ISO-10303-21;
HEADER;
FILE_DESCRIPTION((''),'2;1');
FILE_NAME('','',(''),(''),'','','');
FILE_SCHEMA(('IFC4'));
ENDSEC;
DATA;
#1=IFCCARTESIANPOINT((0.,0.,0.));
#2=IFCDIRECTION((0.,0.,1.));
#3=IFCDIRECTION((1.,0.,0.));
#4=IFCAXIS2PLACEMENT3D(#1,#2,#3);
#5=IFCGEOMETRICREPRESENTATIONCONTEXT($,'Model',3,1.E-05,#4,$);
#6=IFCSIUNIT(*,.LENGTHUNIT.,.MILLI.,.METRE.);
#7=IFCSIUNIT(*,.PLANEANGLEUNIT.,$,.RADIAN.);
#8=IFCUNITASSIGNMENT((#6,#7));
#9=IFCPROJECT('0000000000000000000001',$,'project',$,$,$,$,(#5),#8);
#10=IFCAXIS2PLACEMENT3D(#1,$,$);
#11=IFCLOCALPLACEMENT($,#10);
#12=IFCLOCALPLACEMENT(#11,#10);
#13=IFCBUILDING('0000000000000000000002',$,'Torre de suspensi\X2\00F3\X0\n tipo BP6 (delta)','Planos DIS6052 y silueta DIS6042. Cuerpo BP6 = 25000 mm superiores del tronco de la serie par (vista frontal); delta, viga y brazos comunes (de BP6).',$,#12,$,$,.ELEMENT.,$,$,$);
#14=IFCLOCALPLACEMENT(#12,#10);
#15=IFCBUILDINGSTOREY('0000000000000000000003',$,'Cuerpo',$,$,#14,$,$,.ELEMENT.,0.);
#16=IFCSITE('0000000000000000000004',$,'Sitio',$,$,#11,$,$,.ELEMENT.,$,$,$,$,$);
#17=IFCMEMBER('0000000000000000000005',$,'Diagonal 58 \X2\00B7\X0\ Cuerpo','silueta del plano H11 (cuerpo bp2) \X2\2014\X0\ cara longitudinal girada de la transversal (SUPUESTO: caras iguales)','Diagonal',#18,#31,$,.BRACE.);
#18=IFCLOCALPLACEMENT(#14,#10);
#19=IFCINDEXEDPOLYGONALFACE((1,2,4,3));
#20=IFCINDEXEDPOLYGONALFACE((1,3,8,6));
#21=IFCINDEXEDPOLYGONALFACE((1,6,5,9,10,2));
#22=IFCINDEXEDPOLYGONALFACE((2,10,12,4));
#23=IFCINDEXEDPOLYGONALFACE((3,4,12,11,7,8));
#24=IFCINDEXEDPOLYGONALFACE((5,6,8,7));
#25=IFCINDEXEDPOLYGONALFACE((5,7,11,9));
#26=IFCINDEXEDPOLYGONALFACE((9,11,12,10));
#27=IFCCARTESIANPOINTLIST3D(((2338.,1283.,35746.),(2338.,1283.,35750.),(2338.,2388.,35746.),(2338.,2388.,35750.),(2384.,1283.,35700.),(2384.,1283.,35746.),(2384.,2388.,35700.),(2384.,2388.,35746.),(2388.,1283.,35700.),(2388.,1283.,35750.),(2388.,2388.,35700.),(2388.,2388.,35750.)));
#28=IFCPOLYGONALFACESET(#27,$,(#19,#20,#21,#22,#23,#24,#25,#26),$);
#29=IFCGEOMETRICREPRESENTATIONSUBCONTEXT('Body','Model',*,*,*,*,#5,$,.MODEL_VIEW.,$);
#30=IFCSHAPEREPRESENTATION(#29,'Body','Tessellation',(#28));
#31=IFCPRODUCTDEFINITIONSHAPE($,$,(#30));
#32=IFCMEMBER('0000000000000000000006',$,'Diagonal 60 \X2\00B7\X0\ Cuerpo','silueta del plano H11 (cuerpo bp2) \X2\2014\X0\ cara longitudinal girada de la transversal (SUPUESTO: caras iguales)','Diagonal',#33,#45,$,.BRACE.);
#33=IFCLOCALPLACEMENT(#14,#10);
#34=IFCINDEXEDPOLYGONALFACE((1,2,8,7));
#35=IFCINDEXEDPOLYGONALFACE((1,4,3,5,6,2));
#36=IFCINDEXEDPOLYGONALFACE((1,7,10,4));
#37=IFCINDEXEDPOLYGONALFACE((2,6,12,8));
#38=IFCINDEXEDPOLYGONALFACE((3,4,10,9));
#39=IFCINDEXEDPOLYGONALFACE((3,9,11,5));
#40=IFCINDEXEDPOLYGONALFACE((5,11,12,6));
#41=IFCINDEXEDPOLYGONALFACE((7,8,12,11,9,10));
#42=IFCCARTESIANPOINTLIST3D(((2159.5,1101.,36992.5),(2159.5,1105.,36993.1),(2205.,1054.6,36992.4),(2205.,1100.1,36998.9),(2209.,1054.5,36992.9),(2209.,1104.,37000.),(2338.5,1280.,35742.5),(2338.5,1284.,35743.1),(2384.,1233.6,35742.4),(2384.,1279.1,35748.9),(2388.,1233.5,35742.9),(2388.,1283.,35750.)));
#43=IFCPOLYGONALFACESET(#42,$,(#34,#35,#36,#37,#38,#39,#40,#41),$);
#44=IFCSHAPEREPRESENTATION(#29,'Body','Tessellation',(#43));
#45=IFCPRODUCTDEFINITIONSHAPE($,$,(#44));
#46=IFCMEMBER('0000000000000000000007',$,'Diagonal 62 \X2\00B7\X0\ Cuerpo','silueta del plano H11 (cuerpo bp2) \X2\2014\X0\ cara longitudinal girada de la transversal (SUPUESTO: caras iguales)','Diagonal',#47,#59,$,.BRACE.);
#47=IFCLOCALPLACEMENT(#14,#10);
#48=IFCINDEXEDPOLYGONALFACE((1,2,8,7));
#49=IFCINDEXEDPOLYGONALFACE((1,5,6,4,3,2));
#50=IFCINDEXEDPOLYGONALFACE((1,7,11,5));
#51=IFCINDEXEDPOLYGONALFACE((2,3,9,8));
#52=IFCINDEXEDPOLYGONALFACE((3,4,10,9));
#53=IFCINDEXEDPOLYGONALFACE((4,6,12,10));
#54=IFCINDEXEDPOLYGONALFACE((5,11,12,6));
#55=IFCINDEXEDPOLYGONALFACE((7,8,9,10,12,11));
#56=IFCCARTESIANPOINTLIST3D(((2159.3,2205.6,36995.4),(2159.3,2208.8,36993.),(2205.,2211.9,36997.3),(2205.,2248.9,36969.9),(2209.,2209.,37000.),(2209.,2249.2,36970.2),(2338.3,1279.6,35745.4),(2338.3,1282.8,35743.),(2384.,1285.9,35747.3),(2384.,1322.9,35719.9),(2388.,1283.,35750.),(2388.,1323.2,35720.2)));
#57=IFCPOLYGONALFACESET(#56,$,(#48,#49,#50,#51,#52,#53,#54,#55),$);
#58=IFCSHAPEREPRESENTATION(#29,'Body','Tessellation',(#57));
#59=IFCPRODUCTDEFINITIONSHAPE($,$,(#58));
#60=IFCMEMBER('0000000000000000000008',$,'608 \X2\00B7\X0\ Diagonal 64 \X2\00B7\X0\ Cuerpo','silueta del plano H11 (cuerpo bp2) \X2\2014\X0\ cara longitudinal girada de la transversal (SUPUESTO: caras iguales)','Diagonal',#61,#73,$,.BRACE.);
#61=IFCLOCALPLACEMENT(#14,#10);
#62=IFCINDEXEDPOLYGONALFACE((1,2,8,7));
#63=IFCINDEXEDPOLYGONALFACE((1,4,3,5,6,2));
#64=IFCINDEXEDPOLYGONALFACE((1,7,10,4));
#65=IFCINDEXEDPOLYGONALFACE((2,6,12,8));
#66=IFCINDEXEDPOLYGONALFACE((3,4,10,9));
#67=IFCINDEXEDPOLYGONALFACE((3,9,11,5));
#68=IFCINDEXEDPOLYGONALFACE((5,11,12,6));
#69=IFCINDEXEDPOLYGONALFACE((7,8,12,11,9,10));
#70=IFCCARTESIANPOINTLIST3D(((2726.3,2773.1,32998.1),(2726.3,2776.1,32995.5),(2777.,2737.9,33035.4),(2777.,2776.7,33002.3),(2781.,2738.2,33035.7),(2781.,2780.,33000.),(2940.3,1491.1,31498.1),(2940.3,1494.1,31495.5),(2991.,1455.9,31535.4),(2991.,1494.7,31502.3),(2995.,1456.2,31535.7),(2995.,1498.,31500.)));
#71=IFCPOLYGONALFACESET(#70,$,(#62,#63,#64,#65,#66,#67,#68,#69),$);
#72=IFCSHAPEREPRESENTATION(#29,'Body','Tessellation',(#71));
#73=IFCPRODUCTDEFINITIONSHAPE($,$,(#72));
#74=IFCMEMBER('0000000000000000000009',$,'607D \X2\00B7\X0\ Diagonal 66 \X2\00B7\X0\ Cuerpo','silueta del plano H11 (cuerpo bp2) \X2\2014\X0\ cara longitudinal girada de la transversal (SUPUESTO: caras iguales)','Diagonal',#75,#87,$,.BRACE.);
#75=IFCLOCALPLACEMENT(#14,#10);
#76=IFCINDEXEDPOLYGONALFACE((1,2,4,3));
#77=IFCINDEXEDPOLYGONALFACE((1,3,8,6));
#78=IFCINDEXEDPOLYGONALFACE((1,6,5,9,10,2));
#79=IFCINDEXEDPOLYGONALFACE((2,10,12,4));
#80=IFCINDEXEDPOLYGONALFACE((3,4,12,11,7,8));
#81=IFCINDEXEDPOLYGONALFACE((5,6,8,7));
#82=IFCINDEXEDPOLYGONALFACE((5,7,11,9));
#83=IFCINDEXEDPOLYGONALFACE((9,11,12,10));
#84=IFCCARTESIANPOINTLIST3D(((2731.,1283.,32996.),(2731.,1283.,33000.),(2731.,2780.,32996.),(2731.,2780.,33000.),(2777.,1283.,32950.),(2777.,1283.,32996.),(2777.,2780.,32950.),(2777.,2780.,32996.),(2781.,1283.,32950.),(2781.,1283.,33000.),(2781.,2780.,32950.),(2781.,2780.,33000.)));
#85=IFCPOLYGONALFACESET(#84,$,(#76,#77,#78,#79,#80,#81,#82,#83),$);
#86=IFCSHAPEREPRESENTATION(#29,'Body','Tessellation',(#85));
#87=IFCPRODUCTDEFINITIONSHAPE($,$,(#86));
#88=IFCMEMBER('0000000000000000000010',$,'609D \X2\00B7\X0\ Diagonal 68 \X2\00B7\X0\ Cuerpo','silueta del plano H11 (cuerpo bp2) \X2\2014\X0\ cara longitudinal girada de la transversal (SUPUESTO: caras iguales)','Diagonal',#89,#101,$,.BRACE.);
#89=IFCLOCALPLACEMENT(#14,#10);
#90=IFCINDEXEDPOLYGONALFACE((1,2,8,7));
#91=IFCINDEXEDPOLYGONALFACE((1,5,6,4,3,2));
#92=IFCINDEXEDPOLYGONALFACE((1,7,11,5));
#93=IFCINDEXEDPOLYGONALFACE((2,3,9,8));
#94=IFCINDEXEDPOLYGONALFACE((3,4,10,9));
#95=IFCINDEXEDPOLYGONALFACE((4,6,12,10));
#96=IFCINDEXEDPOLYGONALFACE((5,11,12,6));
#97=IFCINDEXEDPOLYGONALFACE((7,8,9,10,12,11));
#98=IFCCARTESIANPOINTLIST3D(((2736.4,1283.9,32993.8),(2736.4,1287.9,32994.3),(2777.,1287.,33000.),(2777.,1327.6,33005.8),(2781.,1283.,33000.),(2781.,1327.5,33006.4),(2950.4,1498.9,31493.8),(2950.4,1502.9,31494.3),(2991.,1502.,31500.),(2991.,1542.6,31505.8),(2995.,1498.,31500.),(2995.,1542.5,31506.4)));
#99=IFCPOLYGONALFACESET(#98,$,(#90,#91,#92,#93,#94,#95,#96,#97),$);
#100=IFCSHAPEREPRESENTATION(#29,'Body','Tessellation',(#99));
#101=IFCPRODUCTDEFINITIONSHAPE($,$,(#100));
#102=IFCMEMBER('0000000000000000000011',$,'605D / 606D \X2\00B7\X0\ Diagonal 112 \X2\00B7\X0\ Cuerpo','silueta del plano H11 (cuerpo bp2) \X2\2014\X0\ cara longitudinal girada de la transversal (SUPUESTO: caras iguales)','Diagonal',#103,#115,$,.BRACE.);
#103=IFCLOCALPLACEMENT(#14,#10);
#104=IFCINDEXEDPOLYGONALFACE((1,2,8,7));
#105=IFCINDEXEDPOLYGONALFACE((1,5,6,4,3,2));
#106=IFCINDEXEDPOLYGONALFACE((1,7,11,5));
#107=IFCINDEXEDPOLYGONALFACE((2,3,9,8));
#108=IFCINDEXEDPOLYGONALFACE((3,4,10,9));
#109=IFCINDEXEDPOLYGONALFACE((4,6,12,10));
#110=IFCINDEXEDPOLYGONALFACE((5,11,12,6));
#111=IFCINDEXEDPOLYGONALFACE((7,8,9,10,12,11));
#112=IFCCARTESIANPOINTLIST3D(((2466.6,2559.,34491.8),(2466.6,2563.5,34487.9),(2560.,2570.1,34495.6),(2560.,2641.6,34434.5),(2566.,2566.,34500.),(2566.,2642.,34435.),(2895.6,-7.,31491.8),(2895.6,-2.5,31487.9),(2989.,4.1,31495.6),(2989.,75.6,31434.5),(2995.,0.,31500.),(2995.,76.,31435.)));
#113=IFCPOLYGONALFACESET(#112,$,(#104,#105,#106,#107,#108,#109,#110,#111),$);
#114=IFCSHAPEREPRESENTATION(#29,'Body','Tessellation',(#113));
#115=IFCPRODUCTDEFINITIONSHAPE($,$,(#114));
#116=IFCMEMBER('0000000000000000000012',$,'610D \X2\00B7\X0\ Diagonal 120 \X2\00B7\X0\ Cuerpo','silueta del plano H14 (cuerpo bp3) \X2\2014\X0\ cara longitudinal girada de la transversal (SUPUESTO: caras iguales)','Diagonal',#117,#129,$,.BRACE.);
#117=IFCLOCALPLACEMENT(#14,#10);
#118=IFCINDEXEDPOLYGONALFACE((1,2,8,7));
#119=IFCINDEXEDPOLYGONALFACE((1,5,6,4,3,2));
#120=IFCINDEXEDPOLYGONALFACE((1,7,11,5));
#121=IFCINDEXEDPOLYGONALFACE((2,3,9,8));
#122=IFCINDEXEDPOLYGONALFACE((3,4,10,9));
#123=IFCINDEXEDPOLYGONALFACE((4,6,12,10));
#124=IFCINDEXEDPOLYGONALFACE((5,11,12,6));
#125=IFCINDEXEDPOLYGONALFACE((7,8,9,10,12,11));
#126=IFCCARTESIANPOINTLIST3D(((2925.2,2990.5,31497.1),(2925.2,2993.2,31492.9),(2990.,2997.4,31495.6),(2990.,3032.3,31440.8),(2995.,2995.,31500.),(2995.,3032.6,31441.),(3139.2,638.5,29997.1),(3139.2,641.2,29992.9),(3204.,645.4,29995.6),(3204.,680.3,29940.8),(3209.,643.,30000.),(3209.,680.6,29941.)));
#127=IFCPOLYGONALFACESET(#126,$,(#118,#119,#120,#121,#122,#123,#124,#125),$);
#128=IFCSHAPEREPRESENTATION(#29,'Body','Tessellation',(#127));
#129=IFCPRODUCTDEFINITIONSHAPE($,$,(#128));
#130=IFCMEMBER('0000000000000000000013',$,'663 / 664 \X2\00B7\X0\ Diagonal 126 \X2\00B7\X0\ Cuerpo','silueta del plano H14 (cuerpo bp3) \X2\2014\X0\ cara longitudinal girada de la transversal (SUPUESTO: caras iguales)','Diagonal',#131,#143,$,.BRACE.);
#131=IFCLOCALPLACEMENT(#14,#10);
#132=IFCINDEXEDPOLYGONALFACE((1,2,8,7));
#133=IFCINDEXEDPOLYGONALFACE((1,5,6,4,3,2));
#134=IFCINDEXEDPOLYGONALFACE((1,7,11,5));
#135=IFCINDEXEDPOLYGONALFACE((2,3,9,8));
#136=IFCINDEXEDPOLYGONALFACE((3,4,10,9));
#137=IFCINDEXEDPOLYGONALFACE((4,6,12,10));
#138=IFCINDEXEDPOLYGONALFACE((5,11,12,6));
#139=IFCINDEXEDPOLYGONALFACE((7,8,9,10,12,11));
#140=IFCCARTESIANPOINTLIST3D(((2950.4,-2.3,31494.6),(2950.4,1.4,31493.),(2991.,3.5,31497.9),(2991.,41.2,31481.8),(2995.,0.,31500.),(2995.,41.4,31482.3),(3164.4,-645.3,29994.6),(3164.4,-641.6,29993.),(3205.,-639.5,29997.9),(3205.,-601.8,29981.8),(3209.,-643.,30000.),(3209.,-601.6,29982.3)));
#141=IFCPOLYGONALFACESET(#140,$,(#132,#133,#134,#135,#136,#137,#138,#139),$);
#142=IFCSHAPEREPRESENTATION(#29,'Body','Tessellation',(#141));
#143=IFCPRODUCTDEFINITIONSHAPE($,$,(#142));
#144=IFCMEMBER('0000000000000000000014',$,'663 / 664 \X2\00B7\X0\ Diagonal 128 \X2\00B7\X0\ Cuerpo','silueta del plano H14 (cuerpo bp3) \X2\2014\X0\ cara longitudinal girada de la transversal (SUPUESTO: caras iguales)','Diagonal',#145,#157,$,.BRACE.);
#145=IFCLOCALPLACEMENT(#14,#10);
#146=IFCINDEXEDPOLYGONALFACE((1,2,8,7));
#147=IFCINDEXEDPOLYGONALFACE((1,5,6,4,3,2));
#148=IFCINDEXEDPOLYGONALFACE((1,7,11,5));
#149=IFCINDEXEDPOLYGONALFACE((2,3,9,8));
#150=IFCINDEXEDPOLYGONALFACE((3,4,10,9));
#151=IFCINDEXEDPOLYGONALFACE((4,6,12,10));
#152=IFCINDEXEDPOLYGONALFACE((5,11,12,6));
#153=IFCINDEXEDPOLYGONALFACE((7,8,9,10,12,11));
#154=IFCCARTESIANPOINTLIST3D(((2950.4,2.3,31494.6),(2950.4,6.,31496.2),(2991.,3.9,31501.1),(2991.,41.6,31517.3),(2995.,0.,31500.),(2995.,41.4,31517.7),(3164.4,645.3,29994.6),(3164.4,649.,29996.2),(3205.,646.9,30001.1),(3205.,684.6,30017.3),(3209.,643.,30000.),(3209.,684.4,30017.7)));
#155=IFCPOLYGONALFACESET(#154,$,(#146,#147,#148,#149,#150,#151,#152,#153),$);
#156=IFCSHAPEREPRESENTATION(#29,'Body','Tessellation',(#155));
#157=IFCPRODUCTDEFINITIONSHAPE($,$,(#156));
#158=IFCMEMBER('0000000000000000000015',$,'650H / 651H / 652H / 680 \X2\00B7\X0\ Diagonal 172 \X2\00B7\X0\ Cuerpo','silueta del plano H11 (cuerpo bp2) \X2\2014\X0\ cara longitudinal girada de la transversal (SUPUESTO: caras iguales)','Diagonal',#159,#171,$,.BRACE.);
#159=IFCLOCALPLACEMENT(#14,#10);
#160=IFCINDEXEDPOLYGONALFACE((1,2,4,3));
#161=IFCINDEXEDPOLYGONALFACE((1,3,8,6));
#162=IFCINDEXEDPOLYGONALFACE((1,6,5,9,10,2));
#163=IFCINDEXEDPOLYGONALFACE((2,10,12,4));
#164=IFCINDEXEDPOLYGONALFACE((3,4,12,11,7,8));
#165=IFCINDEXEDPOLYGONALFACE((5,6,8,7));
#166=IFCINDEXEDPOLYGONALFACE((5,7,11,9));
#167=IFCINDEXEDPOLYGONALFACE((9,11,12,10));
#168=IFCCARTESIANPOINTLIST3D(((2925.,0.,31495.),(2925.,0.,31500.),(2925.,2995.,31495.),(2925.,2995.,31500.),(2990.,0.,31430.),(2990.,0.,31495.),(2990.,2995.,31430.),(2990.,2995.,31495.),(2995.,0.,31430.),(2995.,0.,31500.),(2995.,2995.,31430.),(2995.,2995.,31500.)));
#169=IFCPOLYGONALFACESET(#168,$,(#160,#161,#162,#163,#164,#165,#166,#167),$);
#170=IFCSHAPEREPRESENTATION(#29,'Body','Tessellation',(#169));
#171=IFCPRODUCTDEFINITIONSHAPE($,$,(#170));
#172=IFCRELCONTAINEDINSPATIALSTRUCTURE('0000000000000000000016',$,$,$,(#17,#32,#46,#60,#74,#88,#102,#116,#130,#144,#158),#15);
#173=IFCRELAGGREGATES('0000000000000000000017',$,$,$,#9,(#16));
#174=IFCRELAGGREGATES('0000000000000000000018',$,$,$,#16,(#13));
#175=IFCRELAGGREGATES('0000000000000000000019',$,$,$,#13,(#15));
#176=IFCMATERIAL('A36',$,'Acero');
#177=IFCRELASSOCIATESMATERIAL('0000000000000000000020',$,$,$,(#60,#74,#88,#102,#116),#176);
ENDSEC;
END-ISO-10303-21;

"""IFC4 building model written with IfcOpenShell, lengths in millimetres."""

from ifc_helpers import new_model, si_unit, frame, frame_2d, origin, origin_with_axes, place, context, subcontext, project, spatial, l_section, extrude, material, element, save


model = new_model("IFC4")

# Units and contexts
model_context = context("Model", 3, precision=1e-05, world=origin_with_axes())
body_context = subcontext(model_context, "Body", "Model", "MODEL_VIEW")
ifc_project = project(units=[si_unit("LENGTHUNIT", "METRE", prefix="MILLI"), si_unit("PLANEANGLEUNIT", "RADIAN")], contexts=[model_context])

# Site, building, storey
site_placement = place(None, origin())
site = spatial("IfcSite", under=ifc_project, at=site_placement, Name="Sitio", CompositionType="ELEMENT")
building_placement = place(site_placement, origin())
building = spatial("IfcBuilding", under=site, at=building_placement, Name="Torre de suspensión tipo BP6 (delta)", Description="Planos DIS6052 y silueta DIS6042. Cuerpo BP6 = 25000 mm superiores del tronco de la serie par (vista frontal); delta, viga y brazos comunes (de BP6).", CompositionType="ELEMENT")
storey_placement = place(building_placement, origin())
storey = spatial("IfcBuildingStorey", under=building, at=storey_placement, Name="Cuerpo", CompositionType="ELEMENT", Elevation=0.0)

# Members
ifc_material_1 = material(Name="A36", Category="Acero")
member_1_placement = place(storey_placement, frame((2388.0, 2388.0, 35750.0), z_axis=(0.0, -1.0, 0.0), x_axis=(-1.0, 0.0, 0.0)))
element("IfcMember", 1, at=member_1_placement, inside=storey, Name="Diagonal 58 · Cuerpo", Description="silueta del plano H11 (cuerpo bp2) — cara longitudinal girada de la transversal (SUPUESTO: caras iguales)", ObjectType="Diagonal", PredefinedType="BRACE", context=body_context, shape_type="SweptSolid", body=[
    extrude(l_section(Depth=50.0, Width=50.0, Thickness=4.0, at=frame_2d((25.0, 25.0))), None, (0.0, 0.0, 1.0), 1105.0),
])
member_2_placement = place(storey_placement, frame((2388.0, 1283.0, 35750.0), z_axis=(-0.140351, -0.140351, 0.980104), x_axis=(-0.990102, 0.019895, -0.138934)))
element("IfcMember", 2, at=member_2_placement, inside=storey, Name="Diagonal 60 · Cuerpo", Description="silueta del plano H11 (cuerpo bp2) — cara longitudinal girada de la transversal (SUPUESTO: caras iguales)", ObjectType="Diagonal", PredefinedType="BRACE", context=body_context, shape_type="SweptSolid", body=[
    extrude(l_section(Depth=50.0, Width=50.0, Thickness=4.0, at=frame_2d((25.0, 25.0))), None, (0.0, 0.0, 1.0), 1275.4),
])
member_3_placement = place(storey_placement, frame((2209.0, 2209.0, 37000.0), z_axis=(0.114312, -0.591356, -0.798267), x_axis=(-0.993445, -0.068045, -0.091854)))
element("IfcMember", 3, at=member_3_placement, inside=storey, Name="Diagonal 62 · Cuerpo", Description="silueta del plano H11 (cuerpo bp2) — cara longitudinal girada de la transversal (SUPUESTO: caras iguales)", ObjectType="Diagonal", PredefinedType="BRACE", context=body_context, shape_type="SweptSolid", body=[
    extrude(l_section(Depth=50.0, Width=50.0, Thickness=4.0, at=frame_2d((25.0, 25.0))), None, (0.0, 0.0, 1.0), 1565.9),
])
member_4_placement = place(storey_placement, frame((2995.0, 1498.0, 31500.0), z_axis=(-0.107821, 0.645918, 0.755754), x_axis=(-0.99417, -0.070052, -0.081964)))
element("IfcMember", 4, at=member_4_placement, inside=storey, material=ifc_material_1, Name="608 · Diagonal 64 · Cuerpo", Description="silueta del plano H11 (cuerpo bp2) — cara longitudinal girada de la transversal (SUPUESTO: caras iguales)", ObjectType="Diagonal", PredefinedType="BRACE", context=body_context, shape_type="SweptSolid", body=[
    extrude(l_section(Depth=55.0, Width=55.0, Thickness=4.0, at=frame_2d((27.5, 27.5))), None, (0.0, 0.0, 1.0), 1984.8),
])
member_5_placement = place(storey_placement, frame((2781.0, 2780.0, 33000.0), z_axis=(0.0, -1.0, 0.0), x_axis=(-1.0, 0.0, 0.0)))
element("IfcMember", 5, at=member_5_placement, inside=storey, material=ifc_material_1, Name="607D · Diagonal 66 · Cuerpo", Description="silueta del plano H11 (cuerpo bp2) — cara longitudinal girada de la transversal (SUPUESTO: caras iguales)", ObjectType="Diagonal", PredefinedType="BRACE", context=body_context, shape_type="SweptSolid", body=[
    extrude(l_section(Depth=50.0, Width=50.0, Thickness=4.0, at=frame_2d((25.0, 25.0))), None, (0.0, 0.0, 1.0), 1497.0),
])
member_6_placement = place(storey_placement, frame((2781.0, 1283.0, 33000.0), z_axis=(0.139836, 0.140489, -0.980157), x_axis=(-0.990175, 0.01984, -0.138421)))
element("IfcMember", 6, at=member_6_placement, inside=storey, material=ifc_material_1, Name="609D · Diagonal 68 · Cuerpo", Description="silueta del plano H11 (cuerpo bp2) — cara longitudinal girada de la transversal (SUPUESTO: caras iguales)", ObjectType="Diagonal", PredefinedType="BRACE", context=body_context, shape_type="SweptSolid", body=[
    extrude(l_section(Depth=45.0, Width=45.0, Thickness=4.0, at=frame_2d((22.5, 22.5))), None, (0.0, 0.0, 1.0), 1530.4),
])
member_7_placement = place(storey_placement, frame((2566.0, 2566.0, 34500.0), z_axis=(0.108035, -0.646194, -0.755488), x_axis=(-0.994147, -0.070222, -0.082099)))
element("IfcMember", 7, at=member_7_placement, inside=storey, material=ifc_material_1, Name="605D / 606D · Diagonal 112 · Cuerpo", Description="silueta del plano H11 (cuerpo bp2) — cara longitudinal girada de la transversal (SUPUESTO: caras iguales)", ObjectType="Diagonal", PredefinedType="BRACE", context=body_context, shape_type="SweptSolid", body=[
    extrude(l_section(Depth=100.0, Width=100.0, Thickness=6.0, at=frame_2d((50.0, 50.0))), None, (0.0, 0.0, 1.0), 3970.9),
])
member_8_placement = place(storey_placement, frame((2995.0, 2995.0, 31500.0), z_axis=(0.076489, -0.84066, -0.536135), x_axis=(-0.99707, -0.06449, -0.041129)))
element("IfcMember", 8, at=member_8_placement, inside=storey, material=ifc_material_1, Name="610D · Diagonal 120 · Cuerpo", Description="silueta del plano H14 (cuerpo bp3) — cara longitudinal girada de la transversal (SUPUESTO: caras iguales)", ObjectType="Diagonal", PredefinedType="BRACE", context=body_context, shape_type="SweptSolid", body=[
    extrude(l_section(Depth=70.0, Width=70.0, Thickness=5.0, at=frame_2d((35.0, 35.0))), None, (0.0, 0.0, 1.0), 2797.8),
])
for number, where, z_axis, x_axis, name in (
    (9, (2995.0, 0.0, 31500.0), (0.130014, -0.390649, -0.911312), (-0.991512, -0.051225, -0.119497), "663 / 664 · Diagonal 126 · Cuerpo"),
    (10, (2995.0, 0.0, 31500.0), (0.130014, 0.390649, -0.911312), (-0.991512, 0.051225, -0.119497), "663 / 664 · Diagonal 128 · Cuerpo"),
):
    element("IfcMember", number, at=place(storey_placement, frame(where, z_axis=z_axis, x_axis=x_axis)), inside=storey, Name=name, Description="silueta del plano H14 (cuerpo bp3) — cara longitudinal girada de la transversal (SUPUESTO: caras iguales)", ObjectType="Diagonal", PredefinedType="BRACE", context=body_context, shape_type="SweptSolid", body=[
        extrude(l_section(Depth=45.0, Width=45.0, Thickness=4.0, at=frame_2d((22.5, 22.5))), None, (0.0, 0.0, 1.0), 1646.0),
    ])
member_9_placement = place(storey_placement, frame((2995.0, 2995.0, 31500.0), z_axis=(0.0, -1.0, 0.0), x_axis=(-1.0, 0.0, 0.0)))
element("IfcMember", 11, at=member_9_placement, inside=storey, Name="650H / 651H / 652H / 680 · Diagonal 172 · Cuerpo", Description="silueta del plano H11 (cuerpo bp2) — cara longitudinal girada de la transversal (SUPUESTO: caras iguales)", ObjectType="Diagonal", PredefinedType="BRACE", context=body_context, shape_type="SweptSolid", body=[
    extrude(l_section(Depth=70.0, Width=70.0, Thickness=5.0, at=frame_2d((35.0, 35.0))), None, (0.0, 0.0, 1.0), 2995.0),
])

save(model, "model.ifc")
